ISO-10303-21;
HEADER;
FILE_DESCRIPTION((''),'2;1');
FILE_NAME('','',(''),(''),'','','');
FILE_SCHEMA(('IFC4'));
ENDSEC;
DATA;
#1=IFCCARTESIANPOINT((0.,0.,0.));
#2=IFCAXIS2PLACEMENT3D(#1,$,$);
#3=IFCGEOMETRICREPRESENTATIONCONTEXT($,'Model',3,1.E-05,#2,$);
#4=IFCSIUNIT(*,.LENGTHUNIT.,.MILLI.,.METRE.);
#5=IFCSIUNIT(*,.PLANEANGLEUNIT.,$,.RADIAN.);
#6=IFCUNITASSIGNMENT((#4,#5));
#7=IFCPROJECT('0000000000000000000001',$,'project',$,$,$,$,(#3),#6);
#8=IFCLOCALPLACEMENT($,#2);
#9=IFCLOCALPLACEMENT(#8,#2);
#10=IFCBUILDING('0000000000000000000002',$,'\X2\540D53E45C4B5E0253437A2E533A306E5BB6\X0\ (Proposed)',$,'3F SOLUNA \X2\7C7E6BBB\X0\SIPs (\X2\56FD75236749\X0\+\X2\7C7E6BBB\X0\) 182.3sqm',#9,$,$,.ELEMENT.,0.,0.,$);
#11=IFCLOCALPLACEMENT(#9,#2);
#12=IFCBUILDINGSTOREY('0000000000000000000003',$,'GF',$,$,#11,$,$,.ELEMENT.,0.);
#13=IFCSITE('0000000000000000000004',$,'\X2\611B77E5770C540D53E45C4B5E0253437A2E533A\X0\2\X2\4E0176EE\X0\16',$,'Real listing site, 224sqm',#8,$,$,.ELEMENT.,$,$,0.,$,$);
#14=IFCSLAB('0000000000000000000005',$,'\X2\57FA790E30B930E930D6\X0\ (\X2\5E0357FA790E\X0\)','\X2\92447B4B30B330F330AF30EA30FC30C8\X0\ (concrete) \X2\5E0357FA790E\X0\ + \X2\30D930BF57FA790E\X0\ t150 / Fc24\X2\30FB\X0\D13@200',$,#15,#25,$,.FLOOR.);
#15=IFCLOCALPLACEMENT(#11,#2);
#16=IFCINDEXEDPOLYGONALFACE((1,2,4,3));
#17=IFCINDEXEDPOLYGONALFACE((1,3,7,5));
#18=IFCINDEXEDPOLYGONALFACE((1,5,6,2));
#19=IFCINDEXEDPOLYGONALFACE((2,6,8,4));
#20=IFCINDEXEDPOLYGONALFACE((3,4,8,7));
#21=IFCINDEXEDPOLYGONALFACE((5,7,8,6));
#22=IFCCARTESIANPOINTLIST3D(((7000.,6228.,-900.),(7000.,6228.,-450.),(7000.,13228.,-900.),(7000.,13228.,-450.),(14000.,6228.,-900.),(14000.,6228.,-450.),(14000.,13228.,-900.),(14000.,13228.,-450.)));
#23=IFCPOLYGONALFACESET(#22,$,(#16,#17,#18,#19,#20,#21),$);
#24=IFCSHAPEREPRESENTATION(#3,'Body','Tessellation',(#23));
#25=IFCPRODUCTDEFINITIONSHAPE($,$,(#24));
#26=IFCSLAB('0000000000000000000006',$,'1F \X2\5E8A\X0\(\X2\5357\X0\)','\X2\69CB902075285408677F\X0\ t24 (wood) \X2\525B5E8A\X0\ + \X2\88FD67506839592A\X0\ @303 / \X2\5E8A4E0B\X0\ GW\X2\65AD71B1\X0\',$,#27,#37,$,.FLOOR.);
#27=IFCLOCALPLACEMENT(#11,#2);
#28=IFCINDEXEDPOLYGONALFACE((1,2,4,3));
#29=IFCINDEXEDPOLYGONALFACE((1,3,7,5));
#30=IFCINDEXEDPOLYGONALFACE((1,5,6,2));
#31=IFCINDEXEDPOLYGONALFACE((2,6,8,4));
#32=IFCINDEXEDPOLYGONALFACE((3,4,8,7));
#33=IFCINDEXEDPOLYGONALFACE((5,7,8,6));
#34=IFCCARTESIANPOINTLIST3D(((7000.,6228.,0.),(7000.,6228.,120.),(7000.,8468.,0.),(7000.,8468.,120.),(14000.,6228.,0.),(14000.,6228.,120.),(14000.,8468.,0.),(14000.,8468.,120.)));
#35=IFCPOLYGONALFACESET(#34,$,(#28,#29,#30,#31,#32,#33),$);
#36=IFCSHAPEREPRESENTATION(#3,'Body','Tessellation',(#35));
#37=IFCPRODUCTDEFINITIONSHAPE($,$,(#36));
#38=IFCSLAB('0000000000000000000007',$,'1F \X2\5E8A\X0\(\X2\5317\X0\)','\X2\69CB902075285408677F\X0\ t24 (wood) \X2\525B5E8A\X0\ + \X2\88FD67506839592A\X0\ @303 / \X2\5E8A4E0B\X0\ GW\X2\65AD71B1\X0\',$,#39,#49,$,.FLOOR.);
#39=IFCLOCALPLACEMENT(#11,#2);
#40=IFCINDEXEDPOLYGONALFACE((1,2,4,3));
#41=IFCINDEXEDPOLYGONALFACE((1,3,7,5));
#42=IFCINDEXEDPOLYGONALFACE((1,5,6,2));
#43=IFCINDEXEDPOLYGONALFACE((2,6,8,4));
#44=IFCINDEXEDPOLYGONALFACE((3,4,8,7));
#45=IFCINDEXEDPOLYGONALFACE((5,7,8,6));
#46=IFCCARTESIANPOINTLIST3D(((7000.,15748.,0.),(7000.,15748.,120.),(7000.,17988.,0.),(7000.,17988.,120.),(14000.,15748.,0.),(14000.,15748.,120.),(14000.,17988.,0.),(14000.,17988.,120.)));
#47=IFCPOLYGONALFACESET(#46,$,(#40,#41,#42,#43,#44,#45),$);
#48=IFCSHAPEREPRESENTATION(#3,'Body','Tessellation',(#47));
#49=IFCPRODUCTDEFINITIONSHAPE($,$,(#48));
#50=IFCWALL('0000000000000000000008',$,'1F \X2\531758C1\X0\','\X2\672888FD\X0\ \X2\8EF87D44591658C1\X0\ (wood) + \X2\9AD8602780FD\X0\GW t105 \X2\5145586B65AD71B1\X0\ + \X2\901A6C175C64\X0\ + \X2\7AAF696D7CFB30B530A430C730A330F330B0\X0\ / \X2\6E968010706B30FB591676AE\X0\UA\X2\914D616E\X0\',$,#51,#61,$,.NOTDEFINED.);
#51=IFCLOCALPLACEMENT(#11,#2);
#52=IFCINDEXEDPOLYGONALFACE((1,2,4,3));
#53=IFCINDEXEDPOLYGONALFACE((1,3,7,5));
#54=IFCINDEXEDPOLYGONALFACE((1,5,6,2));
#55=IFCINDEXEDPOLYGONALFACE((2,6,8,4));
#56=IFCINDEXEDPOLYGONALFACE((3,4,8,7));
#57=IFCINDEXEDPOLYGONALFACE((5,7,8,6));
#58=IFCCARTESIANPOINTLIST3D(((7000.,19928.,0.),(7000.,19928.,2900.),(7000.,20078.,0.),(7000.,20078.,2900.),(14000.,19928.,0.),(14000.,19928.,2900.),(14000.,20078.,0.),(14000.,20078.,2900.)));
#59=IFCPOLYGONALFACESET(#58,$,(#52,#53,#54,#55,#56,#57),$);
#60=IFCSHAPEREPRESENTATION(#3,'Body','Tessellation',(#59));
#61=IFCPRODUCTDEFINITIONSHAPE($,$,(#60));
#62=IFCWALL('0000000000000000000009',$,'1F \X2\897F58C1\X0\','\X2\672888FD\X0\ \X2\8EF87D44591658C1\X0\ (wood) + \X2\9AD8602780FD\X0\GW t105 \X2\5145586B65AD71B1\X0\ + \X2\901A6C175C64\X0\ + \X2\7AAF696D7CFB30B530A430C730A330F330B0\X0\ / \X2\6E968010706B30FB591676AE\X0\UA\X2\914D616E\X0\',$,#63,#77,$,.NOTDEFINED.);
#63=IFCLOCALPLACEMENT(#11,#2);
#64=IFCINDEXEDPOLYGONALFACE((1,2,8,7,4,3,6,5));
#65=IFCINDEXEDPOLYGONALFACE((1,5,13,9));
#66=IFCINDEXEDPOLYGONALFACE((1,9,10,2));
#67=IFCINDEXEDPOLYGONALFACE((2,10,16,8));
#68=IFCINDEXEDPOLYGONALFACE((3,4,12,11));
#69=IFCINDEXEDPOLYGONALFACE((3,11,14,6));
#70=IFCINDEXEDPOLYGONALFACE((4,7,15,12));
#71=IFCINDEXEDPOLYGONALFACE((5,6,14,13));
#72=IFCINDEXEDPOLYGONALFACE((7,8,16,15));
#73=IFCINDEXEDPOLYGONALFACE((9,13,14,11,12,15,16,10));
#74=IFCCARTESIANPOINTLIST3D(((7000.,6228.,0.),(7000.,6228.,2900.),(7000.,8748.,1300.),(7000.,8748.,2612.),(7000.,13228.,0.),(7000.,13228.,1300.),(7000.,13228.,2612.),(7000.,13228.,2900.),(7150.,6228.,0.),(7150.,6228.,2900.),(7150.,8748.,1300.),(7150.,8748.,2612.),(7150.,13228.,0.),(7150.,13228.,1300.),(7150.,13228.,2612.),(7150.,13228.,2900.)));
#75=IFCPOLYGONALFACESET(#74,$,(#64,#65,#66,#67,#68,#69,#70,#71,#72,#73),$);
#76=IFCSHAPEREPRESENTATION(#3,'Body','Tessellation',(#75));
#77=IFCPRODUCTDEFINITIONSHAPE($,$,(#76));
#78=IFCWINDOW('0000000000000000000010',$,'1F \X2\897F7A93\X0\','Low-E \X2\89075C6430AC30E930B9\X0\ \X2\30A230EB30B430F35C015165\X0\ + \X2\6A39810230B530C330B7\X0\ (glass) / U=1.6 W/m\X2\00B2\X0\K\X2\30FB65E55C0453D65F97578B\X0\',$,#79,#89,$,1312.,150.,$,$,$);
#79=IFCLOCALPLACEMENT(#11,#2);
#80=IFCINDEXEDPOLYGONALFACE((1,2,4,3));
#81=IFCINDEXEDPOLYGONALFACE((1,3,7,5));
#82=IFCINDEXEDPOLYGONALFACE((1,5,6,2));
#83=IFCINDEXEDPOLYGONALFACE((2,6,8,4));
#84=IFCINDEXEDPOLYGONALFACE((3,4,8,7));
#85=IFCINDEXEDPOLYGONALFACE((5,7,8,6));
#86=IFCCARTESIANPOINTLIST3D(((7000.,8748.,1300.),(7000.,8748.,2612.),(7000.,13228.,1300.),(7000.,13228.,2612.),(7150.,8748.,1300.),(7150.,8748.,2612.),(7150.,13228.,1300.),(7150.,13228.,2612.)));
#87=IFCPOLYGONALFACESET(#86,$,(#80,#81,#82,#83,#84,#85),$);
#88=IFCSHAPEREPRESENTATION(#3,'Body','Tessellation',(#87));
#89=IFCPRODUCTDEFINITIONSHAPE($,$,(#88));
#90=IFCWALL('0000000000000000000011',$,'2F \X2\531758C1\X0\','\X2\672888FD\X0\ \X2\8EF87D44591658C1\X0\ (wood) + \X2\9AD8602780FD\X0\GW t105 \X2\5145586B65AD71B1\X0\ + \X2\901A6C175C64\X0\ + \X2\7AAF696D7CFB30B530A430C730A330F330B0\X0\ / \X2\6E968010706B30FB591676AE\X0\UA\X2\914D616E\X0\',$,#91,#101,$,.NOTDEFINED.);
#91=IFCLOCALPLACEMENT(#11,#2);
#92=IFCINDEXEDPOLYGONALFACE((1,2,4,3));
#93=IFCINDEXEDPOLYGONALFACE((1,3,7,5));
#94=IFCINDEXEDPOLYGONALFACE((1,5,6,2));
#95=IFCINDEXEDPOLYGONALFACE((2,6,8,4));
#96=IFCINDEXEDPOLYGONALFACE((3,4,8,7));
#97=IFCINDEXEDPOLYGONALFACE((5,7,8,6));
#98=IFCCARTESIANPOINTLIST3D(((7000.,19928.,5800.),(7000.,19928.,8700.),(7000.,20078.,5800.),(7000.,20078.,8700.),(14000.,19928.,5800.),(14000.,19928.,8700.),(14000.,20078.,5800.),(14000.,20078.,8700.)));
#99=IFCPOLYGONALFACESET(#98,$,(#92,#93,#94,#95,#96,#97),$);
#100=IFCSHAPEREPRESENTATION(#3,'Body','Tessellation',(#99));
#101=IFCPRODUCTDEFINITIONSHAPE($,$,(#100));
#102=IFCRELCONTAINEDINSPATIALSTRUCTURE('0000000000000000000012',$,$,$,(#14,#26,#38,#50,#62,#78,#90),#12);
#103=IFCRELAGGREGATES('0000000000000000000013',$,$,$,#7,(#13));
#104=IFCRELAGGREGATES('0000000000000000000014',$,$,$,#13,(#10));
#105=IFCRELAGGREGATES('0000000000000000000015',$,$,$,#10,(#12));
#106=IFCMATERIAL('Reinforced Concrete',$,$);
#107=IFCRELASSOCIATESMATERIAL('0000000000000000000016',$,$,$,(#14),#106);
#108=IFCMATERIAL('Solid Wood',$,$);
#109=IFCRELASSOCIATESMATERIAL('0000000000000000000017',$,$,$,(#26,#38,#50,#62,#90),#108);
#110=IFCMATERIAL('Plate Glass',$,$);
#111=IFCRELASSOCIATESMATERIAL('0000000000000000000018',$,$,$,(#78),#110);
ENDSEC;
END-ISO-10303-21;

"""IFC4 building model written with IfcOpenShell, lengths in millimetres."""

from ifc_helpers import new_model, si_unit, frame, frame_2d, origin, place, context, project, spatial, rectangle, extrude, material, element, fill, save


model = new_model("IFC4")

# Units and contexts
model_context = context("Model", 3, precision=1e-05, world=origin())
ifc_project = project(units=[si_unit("LENGTHUNIT", "METRE", prefix="MILLI"), si_unit("PLANEANGLEUNIT", "RADIAN")], contexts=[model_context])

# Site, building, storey
site_placement = place(None, origin())
site = spatial("IfcSite", under=ifc_project, at=site_placement, Name="愛知県名古屋市千種区2丁目16", ObjectType="Real listing site, 224sqm", CompositionType="ELEMENT", RefElevation=0.0)
building_placement = place(site_placement, origin())
building = spatial("IfcBuilding", under=site, at=building_placement, Name="名古屋市千種区の家 (Proposed)", ObjectType="3F SOLUNA 籾殻SIPs (国産杉+籾殻) 182.3sqm", CompositionType="ELEMENT", ElevationOfRefHeight=0.0, ElevationOfTerrain=0.0)
storey_placement = place(building_placement, origin())
storey = spatial("IfcBuildingStorey", under=building, at=storey_placement, Name="GF", CompositionType="ELEMENT", Elevation=0.0)

# Slabs
ifc_material_1 = material(Name="Reinforced Concrete")
slab_1_placement = place(storey_placement, frame((3500.0, 3114.0, -450.0)))
element("IfcSlab", 1, at=slab_1_placement, inside=storey, material=ifc_material_1, Name="基礎スラブ (布基礎)", Description="鉄筋コンクリート (concrete) 布基礎 + ベタ基礎 t150 / Fc24・D13@200", PredefinedType="FLOOR", context=model_context, shape_type="SweptSolid", body=[
    extrude(rectangle(XDim=7000.0, YDim=7000.0, at=frame_2d((3500.0, 3500.0))), frame((3500.0, 3114.0, -450.0)), (0.0, 0.0, 1.0), 450.0),
])
ifc_material_2 = material(Name="Solid Wood")
slab_2_placement = place(storey_placement, frame((3500.0, 3114.0, 0.0)))
element("IfcSlab", 2, at=slab_2_placement, inside=storey, material=ifc_material_2, Name="1F 床(南)", Description="構造用合板 t24 (wood) 剛床 + 製材根太 @303 / 床下 GW断熱", PredefinedType="FLOOR", context=model_context, shape_type="SweptSolid", body=[
    extrude(rectangle(XDim=7000.0, YDim=2240.0, at=frame_2d((3500.0, 1120.0))), frame((3500.0, 3114.0, 0.0)), (0.0, 0.0, 1.0), 120.0),
])
slab_3_placement = place(storey_placement, frame((3500.0, 7874.0, 0.0)))
element("IfcSlab", 3, at=slab_3_placement, inside=storey, material=ifc_material_2, Name="1F 床(北)", Description="構造用合板 t24 (wood) 剛床 + 製材根太 @303 / 床下 GW断熱", PredefinedType="FLOOR", context=model_context, shape_type="SweptSolid", body=[
    extrude(rectangle(XDim=7000.0, YDim=2240.0, at=frame_2d((3500.0, 1120.0))), frame((3500.0, 7874.0, 0.0)), (0.0, 0.0, 1.0), 120.0),
])

# Shared definitions
ifc_material_3 = material(Name="Plate Glass")

# Wall
wall_1_placement = place(storey_placement, frame((3500.0, 9964.0, 0.0)))
element("IfcWall", 4, at=wall_1_placement, inside=storey, material=ifc_material_2, Name="1F 北壁", Description="木製 軸組外壁 (wood) + 高性能GW t105 充填断熱 + 通気層 + 窯業系サイディング / 準耐火・外皮UA配慮", PredefinedType="NOTDEFINED", context=model_context, shape_type="SweptSolid", body=[
    extrude(rectangle(XDim=7000.0, YDim=150.0, at=frame_2d((3500.0, 75.0))), frame((3500.0, 9964.0, 0.0)), (0.0, 0.0, 1.0), 2900.0),
])

# Wall, opening, window
wall_2_placement = place(storey_placement, frame((3500.0, 3114.0, 0.0)))
wall_2 = element("IfcWall", 5, at=wall_2_placement, inside=storey, material=ifc_material_2, Name="1F 西壁", Description="木製 軸組外壁 (wood) + 高性能GW t105 充填断熱 + 通気層 + 窯業系サイディング / 準耐火・外皮UA配慮", PredefinedType="NOTDEFINED", context=model_context, shape_type="SweptSolid", body=[
    extrude(rectangle(XDim=150.0, YDim=7000.0, at=frame_2d((75.0, 3500.0))), frame((3500.0, 3114.0, 0.0)), (0.0, 0.0, 1.0), 2900.0),
])
opening_1_placement = place(storey_placement, frame((3500.0, 4374.0, 650.0)))
opening_1 = element("IfcOpeningElement", 6, at=opening_1_placement, cuts=wall_2, PredefinedType="NOTDEFINED", context=model_context, shape_type="SweptSolid", body=[
    extrude(rectangle(XDim=150.0, YDim=4480.0, at=frame_2d((75.0, 2240.0))), frame((3500.0, 4374.0, 650.0)), (0.0, 0.0, 1.0), 1312.0),
])
window_1_placement = place(storey_placement, frame((3500.0, 4374.0, 650.0)))
window_1 = element("IfcWindow", 7, at=window_1_placement, inside=storey, material=ifc_material_3, Name="1F 西窓", Description="Low-E 複層ガラス アルゴン封入 + 樹脂サッシ (glass) / U=1.6 W/m²K・日射取得型", OverallHeight=1312.0, OverallWidth=150.0, context=model_context, shape_type="SweptSolid", body=[
    extrude(rectangle(XDim=150.0, YDim=4480.0, at=frame_2d((75.0, 2240.0))), frame((3500.0, 4374.0, 650.0)), (0.0, 0.0, 1.0), 1312.0),
])
fill(opening_1, window_1)

# Wall
wall_3_placement = place(storey_placement, frame((3500.0, 9964.0, 2900.0)))
element("IfcWall", 8, at=wall_3_placement, inside=storey, material=ifc_material_2, Name="2F 北壁", Description="木製 軸組外壁 (wood) + 高性能GW t105 充填断熱 + 通気層 + 窯業系サイディング / 準耐火・外皮UA配慮", PredefinedType="NOTDEFINED", context=model_context, shape_type="SweptSolid", body=[
    extrude(rectangle(XDim=7000.0, YDim=150.0, at=frame_2d((3500.0, 75.0))), frame((3500.0, 9964.0, 2900.0)), (0.0, 0.0, 1.0), 2900.0),
])

save(model, "model.ifc")
